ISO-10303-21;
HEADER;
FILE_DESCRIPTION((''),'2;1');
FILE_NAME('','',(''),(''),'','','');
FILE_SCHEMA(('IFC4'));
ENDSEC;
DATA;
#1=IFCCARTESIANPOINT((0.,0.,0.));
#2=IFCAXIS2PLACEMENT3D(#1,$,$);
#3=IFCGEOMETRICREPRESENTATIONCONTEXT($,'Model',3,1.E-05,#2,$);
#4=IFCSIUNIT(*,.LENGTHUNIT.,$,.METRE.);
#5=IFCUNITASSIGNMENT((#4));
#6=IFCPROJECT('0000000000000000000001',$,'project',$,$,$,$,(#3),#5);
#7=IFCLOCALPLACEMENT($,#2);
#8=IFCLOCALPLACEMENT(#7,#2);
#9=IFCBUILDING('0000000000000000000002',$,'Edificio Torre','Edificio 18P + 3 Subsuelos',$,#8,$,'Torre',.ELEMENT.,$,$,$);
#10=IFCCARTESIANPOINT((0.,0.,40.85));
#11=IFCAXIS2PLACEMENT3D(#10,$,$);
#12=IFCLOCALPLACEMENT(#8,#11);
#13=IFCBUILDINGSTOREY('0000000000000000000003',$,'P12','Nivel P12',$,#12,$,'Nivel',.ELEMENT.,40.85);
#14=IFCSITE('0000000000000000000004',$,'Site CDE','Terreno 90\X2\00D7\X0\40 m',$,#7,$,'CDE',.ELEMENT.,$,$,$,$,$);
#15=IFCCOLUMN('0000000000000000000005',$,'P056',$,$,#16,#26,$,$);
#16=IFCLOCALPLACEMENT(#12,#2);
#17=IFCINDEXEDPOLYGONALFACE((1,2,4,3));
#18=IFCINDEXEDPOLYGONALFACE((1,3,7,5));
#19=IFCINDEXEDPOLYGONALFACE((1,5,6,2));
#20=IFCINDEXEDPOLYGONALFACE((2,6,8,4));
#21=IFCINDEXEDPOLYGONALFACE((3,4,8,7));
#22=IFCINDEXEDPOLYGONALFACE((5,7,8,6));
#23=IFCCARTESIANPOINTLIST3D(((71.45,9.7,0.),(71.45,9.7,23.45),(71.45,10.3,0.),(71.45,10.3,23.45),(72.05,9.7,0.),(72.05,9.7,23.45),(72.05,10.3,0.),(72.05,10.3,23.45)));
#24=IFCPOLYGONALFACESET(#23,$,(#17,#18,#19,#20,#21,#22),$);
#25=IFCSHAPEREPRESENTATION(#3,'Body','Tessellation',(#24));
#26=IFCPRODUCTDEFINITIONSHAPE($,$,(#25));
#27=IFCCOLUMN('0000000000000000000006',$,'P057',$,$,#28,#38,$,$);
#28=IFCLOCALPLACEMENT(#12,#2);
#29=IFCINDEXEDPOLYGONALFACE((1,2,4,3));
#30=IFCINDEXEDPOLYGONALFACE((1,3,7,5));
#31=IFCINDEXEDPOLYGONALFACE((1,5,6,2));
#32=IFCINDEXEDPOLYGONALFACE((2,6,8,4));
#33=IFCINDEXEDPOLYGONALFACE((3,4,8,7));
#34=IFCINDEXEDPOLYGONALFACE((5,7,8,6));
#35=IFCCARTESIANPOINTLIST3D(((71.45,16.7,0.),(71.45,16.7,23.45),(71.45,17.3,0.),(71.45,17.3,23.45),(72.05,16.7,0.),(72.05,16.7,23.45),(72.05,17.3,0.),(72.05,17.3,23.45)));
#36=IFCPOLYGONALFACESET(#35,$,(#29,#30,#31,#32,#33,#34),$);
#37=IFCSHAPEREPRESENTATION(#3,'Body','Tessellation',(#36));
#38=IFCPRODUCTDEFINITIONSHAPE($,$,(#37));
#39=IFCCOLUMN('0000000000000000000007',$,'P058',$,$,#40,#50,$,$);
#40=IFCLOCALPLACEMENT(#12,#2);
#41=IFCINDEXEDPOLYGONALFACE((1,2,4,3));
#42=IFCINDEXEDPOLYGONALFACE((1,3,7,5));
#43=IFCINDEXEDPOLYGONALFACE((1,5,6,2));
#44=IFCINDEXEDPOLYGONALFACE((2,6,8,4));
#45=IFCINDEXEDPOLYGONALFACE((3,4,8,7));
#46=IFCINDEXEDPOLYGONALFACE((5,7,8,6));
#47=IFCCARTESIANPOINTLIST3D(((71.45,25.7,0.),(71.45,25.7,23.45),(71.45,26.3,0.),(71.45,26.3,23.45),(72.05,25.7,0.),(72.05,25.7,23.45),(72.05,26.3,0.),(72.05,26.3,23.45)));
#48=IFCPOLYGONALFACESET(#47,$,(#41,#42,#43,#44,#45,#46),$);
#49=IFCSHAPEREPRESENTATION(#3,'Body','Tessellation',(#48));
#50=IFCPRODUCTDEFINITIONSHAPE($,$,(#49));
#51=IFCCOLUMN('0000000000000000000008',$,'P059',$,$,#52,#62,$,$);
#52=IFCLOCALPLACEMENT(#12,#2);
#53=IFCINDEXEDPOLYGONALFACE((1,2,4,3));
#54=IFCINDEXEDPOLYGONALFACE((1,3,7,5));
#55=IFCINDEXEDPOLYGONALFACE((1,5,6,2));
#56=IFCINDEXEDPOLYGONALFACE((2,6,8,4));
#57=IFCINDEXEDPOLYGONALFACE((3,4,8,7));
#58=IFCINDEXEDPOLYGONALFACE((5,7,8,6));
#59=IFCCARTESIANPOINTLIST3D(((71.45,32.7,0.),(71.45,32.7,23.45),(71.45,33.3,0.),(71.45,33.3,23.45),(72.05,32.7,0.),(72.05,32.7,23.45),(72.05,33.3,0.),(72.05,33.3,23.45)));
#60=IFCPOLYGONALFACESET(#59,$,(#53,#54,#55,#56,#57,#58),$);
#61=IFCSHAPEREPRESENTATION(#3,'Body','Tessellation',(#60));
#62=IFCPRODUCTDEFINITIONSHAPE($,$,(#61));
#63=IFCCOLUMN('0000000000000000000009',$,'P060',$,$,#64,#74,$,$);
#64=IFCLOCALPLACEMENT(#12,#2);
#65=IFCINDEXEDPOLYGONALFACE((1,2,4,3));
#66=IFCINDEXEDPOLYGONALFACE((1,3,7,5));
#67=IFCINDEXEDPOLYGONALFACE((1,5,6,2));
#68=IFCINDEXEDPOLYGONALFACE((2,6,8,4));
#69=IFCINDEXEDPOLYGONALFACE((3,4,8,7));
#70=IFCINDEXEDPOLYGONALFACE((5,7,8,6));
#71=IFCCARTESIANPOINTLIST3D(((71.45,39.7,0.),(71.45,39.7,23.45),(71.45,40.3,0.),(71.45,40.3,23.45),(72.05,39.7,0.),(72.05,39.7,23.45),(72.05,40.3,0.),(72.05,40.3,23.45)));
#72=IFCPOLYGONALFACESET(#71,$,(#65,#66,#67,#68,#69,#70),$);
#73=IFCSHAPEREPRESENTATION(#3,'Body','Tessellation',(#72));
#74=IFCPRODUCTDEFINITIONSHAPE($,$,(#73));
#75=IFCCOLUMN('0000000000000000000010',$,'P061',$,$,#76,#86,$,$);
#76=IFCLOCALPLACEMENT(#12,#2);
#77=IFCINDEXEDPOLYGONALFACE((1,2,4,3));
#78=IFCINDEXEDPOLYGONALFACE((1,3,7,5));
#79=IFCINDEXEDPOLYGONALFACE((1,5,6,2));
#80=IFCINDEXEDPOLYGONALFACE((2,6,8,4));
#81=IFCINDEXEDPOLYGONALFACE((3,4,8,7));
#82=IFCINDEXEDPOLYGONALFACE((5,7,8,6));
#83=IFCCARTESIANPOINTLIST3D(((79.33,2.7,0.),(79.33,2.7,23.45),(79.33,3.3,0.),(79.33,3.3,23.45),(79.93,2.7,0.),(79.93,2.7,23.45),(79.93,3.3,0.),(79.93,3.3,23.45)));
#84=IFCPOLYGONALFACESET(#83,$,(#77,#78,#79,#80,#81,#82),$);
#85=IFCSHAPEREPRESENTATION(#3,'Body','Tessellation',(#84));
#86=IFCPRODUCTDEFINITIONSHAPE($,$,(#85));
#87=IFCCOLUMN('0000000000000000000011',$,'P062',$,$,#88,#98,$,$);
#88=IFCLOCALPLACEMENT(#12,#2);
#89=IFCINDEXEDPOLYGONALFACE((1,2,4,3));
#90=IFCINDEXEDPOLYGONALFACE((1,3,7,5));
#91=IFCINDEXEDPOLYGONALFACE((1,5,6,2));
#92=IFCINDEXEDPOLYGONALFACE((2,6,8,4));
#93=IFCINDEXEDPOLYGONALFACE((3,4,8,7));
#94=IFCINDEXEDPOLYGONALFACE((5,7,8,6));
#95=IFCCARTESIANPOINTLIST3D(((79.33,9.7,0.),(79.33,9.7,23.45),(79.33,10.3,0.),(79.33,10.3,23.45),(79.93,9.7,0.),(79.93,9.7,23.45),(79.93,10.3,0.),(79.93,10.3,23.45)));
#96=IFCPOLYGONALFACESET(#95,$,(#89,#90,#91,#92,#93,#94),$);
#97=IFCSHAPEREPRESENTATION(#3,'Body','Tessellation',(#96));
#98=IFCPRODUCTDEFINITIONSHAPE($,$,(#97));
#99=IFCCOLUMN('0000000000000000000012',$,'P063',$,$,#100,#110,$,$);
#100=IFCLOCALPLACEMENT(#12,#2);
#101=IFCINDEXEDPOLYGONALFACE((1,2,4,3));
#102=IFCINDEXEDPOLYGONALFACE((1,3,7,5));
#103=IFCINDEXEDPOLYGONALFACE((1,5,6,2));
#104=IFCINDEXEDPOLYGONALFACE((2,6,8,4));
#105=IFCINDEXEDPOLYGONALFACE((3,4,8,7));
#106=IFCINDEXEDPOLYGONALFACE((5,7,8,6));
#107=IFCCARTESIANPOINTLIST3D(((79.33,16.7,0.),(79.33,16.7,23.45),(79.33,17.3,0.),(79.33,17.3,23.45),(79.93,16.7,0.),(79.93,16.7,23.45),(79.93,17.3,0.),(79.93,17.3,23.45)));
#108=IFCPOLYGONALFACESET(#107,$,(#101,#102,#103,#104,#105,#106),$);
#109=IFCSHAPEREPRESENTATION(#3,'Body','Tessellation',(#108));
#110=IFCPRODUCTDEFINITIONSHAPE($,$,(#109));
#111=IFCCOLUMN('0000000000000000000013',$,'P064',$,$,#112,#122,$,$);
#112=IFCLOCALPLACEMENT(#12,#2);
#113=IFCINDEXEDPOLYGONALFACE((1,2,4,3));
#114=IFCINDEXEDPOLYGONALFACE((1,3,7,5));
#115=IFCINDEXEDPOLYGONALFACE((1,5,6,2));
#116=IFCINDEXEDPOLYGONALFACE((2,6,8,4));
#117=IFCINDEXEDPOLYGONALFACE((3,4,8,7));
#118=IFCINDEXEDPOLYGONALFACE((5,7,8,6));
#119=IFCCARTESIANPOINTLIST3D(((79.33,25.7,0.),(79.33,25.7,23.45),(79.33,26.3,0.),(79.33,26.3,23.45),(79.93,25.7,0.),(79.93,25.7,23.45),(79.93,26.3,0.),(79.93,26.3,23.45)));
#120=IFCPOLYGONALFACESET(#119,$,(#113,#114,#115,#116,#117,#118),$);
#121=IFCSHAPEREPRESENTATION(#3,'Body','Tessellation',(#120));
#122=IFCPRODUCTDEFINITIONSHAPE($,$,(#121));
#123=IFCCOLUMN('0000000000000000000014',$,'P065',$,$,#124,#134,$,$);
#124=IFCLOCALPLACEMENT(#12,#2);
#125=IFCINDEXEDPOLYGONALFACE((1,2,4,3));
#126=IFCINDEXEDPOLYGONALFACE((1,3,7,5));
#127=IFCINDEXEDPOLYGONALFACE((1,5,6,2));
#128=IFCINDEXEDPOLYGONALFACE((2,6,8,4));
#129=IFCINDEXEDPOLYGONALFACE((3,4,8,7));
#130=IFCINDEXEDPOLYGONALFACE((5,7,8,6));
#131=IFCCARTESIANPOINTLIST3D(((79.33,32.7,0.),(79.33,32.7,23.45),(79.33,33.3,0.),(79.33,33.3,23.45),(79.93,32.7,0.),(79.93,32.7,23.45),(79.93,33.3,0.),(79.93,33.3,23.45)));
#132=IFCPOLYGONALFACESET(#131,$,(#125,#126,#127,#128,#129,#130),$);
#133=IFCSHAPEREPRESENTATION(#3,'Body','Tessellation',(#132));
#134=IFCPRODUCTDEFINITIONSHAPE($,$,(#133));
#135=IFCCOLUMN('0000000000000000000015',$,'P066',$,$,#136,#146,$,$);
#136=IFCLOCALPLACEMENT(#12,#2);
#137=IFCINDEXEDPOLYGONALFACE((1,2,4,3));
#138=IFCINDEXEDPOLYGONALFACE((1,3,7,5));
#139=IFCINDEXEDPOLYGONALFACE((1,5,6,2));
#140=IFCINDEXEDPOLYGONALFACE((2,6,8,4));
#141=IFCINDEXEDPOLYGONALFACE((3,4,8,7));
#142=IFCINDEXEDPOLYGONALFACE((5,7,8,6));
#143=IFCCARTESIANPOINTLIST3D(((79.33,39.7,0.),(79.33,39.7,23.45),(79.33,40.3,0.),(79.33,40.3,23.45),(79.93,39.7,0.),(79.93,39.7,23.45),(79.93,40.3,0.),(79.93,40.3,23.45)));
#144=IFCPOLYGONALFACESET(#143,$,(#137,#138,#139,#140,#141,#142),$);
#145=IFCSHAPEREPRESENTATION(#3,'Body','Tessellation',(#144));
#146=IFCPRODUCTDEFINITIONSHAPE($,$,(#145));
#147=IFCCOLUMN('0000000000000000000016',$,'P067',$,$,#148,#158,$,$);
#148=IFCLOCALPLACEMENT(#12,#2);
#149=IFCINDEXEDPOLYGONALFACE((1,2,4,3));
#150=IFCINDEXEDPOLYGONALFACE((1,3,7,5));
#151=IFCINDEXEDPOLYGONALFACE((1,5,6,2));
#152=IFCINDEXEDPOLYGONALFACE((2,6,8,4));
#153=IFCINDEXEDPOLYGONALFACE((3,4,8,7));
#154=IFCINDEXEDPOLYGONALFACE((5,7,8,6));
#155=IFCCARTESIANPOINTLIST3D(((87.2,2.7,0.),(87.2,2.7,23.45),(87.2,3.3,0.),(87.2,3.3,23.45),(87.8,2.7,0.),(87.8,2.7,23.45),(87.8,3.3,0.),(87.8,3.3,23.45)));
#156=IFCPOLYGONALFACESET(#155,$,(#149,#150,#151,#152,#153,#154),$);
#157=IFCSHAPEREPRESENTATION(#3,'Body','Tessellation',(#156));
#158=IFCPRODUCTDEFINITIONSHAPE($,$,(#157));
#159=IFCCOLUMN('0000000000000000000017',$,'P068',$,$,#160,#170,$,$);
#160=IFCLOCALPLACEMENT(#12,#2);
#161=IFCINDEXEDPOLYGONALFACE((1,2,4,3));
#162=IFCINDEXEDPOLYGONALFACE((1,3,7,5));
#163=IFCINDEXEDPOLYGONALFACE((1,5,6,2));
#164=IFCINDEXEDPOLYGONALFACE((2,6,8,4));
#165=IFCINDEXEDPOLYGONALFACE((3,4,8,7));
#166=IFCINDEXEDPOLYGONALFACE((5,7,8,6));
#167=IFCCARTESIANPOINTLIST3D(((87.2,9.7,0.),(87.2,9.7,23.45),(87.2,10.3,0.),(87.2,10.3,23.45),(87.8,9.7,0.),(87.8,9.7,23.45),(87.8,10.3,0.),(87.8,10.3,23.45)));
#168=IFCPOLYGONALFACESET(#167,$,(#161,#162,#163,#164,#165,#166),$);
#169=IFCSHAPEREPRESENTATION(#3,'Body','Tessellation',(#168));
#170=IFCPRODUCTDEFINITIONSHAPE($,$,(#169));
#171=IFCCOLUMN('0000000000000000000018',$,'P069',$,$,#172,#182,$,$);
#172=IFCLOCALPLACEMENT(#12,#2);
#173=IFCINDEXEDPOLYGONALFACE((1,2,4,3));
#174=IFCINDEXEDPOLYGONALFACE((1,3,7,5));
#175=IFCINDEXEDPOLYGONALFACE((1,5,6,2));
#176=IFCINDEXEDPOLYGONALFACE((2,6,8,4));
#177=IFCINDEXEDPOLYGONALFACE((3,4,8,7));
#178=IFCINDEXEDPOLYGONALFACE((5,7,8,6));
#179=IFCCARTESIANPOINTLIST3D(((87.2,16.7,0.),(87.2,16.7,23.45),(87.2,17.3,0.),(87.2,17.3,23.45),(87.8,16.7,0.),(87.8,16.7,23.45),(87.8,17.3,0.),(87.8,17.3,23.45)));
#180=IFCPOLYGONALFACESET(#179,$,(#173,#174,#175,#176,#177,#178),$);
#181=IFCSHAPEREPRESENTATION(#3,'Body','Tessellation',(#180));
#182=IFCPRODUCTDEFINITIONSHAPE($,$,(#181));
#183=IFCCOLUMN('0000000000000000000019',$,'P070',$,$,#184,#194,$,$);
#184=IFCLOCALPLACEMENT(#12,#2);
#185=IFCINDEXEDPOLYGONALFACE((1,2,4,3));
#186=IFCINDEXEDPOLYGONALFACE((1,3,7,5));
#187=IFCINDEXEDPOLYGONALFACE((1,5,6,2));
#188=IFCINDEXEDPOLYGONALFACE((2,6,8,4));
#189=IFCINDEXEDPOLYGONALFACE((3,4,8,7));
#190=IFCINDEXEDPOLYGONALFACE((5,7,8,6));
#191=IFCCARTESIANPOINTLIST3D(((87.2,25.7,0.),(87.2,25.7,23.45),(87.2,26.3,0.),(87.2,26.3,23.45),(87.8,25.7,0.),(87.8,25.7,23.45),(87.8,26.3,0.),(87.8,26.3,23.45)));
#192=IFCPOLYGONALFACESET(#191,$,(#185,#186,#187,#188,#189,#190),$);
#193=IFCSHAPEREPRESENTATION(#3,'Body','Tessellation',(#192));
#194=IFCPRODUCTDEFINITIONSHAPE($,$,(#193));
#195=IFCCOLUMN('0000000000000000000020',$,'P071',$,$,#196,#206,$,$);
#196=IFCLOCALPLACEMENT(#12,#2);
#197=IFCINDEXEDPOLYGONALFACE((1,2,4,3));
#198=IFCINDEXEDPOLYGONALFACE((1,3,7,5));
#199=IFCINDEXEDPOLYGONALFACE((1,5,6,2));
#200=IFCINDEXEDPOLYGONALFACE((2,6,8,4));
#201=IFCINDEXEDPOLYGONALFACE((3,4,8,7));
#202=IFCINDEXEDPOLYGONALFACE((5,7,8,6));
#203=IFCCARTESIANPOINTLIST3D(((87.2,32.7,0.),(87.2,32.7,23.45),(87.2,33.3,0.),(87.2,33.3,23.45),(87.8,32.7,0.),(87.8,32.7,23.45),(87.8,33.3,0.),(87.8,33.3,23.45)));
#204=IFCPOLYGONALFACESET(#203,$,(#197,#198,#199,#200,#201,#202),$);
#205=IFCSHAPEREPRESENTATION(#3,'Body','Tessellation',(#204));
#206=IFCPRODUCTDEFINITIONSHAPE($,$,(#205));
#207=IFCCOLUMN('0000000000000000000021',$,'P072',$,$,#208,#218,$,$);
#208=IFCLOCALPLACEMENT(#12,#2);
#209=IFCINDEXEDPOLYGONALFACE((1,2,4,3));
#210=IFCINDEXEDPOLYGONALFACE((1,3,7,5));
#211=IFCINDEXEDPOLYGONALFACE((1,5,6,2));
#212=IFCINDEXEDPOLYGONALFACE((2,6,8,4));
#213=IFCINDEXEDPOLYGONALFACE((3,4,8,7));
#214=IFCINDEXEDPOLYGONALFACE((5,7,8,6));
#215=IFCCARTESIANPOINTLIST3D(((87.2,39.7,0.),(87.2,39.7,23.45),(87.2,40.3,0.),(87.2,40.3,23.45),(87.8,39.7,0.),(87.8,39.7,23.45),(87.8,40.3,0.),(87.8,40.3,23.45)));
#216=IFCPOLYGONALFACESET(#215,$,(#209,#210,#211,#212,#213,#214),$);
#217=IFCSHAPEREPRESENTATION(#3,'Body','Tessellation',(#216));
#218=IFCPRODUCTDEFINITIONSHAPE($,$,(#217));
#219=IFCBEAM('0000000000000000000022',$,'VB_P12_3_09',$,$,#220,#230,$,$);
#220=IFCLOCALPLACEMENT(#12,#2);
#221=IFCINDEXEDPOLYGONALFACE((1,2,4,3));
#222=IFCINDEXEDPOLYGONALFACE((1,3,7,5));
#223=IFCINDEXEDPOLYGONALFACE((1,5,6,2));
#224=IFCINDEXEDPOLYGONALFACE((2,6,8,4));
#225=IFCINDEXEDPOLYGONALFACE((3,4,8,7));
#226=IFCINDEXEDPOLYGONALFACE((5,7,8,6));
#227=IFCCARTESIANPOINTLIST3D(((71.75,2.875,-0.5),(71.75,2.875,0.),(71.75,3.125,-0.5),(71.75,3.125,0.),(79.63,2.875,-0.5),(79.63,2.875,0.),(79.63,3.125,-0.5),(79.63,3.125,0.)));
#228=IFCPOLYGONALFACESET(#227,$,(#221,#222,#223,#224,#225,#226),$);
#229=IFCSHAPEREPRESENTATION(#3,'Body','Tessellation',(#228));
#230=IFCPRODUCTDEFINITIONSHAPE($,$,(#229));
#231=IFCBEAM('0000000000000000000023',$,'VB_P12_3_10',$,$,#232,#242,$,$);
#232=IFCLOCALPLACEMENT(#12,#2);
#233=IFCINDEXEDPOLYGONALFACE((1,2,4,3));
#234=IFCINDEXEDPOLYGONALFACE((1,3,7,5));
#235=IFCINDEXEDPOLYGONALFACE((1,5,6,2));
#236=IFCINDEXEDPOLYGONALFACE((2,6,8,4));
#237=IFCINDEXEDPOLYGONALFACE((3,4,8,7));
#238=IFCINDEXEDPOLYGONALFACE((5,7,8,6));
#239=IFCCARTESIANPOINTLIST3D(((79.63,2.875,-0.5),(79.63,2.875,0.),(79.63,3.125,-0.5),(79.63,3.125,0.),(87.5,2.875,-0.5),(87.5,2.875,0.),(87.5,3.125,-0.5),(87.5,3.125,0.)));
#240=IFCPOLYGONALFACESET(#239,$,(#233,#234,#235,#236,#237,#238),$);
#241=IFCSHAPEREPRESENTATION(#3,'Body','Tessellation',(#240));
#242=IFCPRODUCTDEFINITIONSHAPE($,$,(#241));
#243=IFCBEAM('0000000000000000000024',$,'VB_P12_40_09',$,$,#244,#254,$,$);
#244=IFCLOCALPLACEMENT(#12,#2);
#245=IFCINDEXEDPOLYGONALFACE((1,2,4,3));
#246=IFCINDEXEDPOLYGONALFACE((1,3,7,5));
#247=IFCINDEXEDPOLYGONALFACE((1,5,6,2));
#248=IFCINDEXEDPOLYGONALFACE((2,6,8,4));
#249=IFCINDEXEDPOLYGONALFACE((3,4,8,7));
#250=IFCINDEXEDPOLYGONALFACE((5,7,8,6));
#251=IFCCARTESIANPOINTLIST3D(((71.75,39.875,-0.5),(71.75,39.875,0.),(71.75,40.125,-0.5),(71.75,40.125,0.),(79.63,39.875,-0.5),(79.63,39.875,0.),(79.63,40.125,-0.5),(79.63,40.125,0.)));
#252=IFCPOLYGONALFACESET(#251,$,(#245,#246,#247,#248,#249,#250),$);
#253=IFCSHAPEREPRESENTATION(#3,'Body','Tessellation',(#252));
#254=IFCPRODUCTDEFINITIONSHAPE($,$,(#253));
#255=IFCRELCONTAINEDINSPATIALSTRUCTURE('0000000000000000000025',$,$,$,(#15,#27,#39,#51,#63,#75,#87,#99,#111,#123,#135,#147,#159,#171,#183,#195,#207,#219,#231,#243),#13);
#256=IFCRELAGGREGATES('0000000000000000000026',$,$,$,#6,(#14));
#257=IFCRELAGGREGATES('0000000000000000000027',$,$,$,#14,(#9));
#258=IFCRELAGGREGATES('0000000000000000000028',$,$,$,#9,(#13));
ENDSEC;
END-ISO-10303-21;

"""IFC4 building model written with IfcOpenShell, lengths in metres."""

from ifc_helpers import new_model, si_unit, frame, origin, origin_2d, place, context, project, spatial, rectangle, extrude, element, save


model = new_model("IFC4")

# Units and contexts
model_context = context("Model", 3, precision=1e-05, world=origin())
ifc_project = project(units=[si_unit("LENGTHUNIT", "METRE")], contexts=[model_context])

# Site, building, storey
site_placement = place(None, origin())
site = spatial("IfcSite", under=ifc_project, at=site_placement, Name="Site CDE", Description="Terreno 90×40 m", LongName="CDE", CompositionType="ELEMENT")
building_placement = place(site_placement, origin())
building = spatial("IfcBuilding", under=site, at=building_placement, Name="Edificio Torre", Description="Edificio 18P + 3 Subsuelos", LongName="Torre", CompositionType="ELEMENT")
storey_placement = place(building_placement, frame((0.0, 0.0, 40.85)))
storey = spatial("IfcBuildingStorey", under=building, at=storey_placement, Name="P12", Description="Nivel P12", LongName="Nivel", CompositionType="ELEMENT", Elevation=40.85)

# Columns
for number, where, name in (
    (1, (71.75, 10.0, 0.0), "P056"),
    (2, (71.75, 17.0, 0.0), "P057"),
    (3, (71.75, 26.0, 0.0), "P058"),
    (4, (71.75, 33.0, 0.0), "P059"),
    (5, (71.75, 40.0, 0.0), "P060"),
    (6, (79.63, 3.0, 0.0), "P061"),
    (7, (79.63, 10.0, 0.0), "P062"),
    (8, (79.63, 17.0, 0.0), "P063"),
    (9, (79.63, 26.0, 0.0), "P064"),
    (10, (79.63, 33.0, 0.0), "P065"),
    (11, (79.63, 40.0, 0.0), "P066"),
    (12, (87.5, 3.0, 0.0), "P067"),
    (13, (87.5, 10.0, 0.0), "P068"),
    (14, (87.5, 17.0, 0.0), "P069"),
    (15, (87.5, 26.0, 0.0), "P070"),
    (16, (87.5, 33.0, 0.0), "P071"),
    (17, (87.5, 40.0, 0.0), "P072"),
):
    element("IfcColumn", number, at=place(storey_placement, frame(where)), inside=storey, Name=name, context=model_context, shape_type="SweptSolid", body=[
        extrude(rectangle(XDim=0.6, YDim=0.6, at=origin_2d()), origin(), (0.0, 0.0, 1.0), 23.45),
    ])

# Beams
beam_1_placement = place(storey_placement, frame((75.69, 3.0, -0.5)))
element("IfcBeam", 18, at=beam_1_placement, inside=storey, Name="VB_P12_3_09", context=model_context, shape_type="SweptSolid", body=[
    extrude(rectangle(XDim=7.88, YDim=0.25, at=origin_2d()), origin(), (0.0, 0.0, 1.0), 0.5),
])
beam_2_placement = place(storey_placement, frame((83.565, 3.0, -0.5)))
element("IfcBeam", 19, at=beam_2_placement, inside=storey, Name="VB_P12_3_10", context=model_context, shape_type="SweptSolid", body=[
    extrude(rectangle(XDim=7.87, YDim=0.25, at=origin_2d()), origin(), (0.0, 0.0, 1.0), 0.5),
])
beam_3_placement = place(storey_placement, frame((75.69, 40.0, -0.5)))
element("IfcBeam", 20, at=beam_3_placement, inside=storey, Name="VB_P12_40_09", context=model_context, shape_type="SweptSolid", body=[
    extrude(rectangle(XDim=7.88, YDim=0.25, at=origin_2d()), origin(), (0.0, 0.0, 1.0), 0.5),
])

save(model, "model.ifc")
